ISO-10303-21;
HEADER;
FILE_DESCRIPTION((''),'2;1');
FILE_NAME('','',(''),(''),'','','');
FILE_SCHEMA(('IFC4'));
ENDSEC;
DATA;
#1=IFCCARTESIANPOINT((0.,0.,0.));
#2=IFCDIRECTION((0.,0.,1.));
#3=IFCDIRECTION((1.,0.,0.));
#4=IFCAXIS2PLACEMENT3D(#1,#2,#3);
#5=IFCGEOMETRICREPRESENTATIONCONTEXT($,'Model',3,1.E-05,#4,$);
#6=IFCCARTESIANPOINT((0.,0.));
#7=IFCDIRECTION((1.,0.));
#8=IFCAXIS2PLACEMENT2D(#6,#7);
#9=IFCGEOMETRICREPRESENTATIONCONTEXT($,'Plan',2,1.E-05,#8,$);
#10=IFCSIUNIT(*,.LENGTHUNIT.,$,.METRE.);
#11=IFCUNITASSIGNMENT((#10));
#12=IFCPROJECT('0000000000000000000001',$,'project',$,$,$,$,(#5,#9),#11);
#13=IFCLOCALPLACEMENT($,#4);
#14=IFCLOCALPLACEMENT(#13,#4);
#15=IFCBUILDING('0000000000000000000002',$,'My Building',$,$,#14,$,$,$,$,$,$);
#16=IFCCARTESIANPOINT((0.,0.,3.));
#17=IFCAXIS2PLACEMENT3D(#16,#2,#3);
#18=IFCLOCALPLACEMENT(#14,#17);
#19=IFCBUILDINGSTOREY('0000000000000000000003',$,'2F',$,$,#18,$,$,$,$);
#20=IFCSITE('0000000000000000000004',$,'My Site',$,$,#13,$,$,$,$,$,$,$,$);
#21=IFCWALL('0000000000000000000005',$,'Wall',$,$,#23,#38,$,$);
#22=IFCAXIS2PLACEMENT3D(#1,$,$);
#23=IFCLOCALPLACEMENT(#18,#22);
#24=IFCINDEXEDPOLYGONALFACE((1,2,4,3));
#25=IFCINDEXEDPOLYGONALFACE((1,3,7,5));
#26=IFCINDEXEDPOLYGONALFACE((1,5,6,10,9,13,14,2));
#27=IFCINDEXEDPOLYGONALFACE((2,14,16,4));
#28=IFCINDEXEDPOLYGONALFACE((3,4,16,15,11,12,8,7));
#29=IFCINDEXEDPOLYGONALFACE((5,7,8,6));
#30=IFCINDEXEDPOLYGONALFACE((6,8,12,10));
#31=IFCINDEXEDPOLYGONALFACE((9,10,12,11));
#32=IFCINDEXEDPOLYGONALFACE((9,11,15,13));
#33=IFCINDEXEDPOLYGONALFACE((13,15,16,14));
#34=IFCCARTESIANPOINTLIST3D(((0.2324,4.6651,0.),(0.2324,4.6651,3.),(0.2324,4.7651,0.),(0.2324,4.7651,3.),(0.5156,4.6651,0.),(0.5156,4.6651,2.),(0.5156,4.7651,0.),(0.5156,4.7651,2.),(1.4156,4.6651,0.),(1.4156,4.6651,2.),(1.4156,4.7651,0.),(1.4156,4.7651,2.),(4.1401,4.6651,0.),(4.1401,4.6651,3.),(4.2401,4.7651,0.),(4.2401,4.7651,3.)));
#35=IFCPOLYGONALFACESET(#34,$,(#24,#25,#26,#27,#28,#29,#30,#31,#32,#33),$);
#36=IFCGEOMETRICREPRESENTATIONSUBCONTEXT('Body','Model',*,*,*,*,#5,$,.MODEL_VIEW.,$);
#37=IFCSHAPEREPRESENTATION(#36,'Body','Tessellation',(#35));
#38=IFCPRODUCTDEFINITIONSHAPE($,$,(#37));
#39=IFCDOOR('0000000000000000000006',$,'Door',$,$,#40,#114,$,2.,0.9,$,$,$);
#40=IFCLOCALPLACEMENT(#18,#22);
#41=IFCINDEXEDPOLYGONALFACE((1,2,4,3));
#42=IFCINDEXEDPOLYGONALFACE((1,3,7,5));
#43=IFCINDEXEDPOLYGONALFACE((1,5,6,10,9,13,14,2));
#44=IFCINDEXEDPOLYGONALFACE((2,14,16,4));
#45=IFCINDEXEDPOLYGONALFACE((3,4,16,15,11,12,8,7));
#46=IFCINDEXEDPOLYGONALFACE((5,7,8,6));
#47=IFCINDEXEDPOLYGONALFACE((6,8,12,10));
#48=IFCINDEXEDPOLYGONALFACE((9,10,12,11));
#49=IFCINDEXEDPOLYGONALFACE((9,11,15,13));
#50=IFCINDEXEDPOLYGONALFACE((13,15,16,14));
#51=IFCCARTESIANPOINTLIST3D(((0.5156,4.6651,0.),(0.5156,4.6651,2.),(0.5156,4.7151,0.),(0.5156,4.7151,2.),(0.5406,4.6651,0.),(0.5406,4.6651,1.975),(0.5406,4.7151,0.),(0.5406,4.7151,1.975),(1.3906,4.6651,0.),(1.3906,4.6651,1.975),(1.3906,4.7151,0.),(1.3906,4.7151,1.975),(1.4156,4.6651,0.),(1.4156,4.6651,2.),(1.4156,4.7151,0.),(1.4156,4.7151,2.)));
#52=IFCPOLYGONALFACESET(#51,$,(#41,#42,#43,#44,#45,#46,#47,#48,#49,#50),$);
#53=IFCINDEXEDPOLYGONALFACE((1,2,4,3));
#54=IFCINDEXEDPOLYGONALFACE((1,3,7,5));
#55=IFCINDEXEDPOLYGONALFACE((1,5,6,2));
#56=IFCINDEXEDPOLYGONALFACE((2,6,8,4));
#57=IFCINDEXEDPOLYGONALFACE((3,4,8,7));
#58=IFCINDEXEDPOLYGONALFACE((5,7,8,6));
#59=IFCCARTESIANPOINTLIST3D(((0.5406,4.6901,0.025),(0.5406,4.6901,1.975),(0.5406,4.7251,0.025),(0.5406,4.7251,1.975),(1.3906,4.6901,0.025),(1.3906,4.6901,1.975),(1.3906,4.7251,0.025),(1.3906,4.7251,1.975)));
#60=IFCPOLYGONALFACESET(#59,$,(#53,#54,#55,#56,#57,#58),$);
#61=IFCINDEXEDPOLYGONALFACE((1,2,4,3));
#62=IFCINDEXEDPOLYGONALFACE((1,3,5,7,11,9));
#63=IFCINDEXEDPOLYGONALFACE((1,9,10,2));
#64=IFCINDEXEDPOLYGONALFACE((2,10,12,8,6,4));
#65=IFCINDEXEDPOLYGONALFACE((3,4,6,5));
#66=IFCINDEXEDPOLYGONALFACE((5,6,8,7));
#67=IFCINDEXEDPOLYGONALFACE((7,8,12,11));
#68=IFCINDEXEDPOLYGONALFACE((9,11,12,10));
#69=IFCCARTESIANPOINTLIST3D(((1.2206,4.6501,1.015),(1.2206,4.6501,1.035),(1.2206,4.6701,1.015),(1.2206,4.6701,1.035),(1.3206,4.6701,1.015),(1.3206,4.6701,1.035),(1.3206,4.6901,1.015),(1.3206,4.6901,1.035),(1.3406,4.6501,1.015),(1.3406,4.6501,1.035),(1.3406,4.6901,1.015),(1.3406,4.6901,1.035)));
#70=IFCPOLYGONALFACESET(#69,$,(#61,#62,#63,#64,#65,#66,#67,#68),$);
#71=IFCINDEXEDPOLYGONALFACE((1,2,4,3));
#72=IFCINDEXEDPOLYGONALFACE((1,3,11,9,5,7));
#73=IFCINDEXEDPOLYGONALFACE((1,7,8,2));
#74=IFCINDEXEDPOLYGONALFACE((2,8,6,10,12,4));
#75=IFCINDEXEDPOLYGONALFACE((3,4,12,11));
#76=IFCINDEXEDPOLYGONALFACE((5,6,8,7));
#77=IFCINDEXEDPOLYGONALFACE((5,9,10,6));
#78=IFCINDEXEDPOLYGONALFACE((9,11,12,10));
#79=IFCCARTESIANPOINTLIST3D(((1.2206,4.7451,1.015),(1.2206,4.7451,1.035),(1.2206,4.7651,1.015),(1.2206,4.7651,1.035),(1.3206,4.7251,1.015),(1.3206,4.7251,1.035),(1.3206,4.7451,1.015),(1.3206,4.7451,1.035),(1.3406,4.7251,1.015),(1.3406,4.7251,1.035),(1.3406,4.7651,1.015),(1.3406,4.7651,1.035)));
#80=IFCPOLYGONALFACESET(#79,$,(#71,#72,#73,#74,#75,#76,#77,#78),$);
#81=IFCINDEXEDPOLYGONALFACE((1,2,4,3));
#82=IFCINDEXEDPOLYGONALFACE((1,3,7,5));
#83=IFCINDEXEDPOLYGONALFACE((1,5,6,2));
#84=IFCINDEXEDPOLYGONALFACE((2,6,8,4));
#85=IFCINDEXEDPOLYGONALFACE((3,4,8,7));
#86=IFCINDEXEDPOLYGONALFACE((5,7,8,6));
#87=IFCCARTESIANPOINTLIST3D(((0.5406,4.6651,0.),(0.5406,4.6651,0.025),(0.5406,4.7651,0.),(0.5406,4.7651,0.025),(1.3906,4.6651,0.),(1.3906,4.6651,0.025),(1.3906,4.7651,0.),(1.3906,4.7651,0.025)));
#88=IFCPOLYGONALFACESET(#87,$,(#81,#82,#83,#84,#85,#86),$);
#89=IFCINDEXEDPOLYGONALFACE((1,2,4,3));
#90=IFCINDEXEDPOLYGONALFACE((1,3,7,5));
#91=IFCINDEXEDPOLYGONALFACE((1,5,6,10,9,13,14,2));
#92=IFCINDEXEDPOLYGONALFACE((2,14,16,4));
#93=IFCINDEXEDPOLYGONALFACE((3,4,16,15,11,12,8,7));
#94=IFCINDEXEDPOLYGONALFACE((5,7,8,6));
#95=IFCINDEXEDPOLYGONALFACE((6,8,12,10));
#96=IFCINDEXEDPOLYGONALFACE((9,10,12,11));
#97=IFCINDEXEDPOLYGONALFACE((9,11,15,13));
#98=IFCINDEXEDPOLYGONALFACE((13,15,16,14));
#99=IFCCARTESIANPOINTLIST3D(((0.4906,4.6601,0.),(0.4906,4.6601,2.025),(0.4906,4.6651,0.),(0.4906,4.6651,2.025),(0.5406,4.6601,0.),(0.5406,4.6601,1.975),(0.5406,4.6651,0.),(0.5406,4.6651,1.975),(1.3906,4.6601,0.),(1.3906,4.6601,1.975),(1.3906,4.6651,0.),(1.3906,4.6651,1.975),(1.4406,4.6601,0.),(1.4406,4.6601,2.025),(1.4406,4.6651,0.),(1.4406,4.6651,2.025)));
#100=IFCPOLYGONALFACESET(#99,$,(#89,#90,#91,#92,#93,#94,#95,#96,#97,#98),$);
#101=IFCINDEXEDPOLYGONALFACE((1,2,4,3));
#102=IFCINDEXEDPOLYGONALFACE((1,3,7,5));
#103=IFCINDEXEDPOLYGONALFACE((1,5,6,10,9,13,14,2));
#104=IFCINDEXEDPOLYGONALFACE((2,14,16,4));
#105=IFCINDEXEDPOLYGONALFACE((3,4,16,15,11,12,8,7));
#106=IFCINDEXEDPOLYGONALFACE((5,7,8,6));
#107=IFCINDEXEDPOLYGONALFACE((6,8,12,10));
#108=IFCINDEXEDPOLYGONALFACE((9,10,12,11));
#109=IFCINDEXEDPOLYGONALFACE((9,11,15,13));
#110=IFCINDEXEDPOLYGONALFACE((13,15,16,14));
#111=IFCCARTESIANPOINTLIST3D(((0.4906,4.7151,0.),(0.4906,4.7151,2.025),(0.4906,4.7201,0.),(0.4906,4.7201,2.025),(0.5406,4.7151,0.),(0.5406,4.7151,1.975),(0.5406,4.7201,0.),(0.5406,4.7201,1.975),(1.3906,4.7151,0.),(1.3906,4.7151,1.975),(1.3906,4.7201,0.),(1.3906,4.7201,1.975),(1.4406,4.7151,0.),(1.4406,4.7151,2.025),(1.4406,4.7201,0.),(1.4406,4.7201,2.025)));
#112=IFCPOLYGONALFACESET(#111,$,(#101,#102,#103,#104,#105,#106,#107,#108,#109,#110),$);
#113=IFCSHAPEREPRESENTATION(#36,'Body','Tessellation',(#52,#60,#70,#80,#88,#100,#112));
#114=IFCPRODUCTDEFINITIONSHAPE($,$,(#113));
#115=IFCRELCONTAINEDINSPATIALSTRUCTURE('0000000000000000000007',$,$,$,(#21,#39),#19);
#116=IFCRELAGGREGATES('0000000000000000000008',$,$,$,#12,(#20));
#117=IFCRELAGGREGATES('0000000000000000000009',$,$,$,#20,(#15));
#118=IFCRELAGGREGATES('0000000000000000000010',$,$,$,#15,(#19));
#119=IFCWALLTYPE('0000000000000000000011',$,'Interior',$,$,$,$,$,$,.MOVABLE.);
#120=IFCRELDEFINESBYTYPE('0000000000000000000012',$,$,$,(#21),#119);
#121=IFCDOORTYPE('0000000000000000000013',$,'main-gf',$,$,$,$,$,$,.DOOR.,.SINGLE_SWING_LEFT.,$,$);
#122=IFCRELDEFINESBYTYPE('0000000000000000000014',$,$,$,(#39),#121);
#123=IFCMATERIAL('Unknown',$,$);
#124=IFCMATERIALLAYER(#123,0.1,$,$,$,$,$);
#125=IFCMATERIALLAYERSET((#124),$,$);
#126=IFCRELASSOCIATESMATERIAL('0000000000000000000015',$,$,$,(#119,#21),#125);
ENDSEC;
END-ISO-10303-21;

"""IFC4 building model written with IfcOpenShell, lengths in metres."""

from ifc_helpers import new_model, entity, si_unit, frame, origin_with_axes, origin_2d_with_axis, place, context, subcontext, project, spatial, line, indexed_curve, outline, extrude, shape, source, transform, mapped, material, layer, layer_set, layer_usage, type_object, type_shapes, element, fill, save


model = new_model("IFC4")

# Units and contexts
model_context = context("Model", 3, precision=1e-05, world=origin_with_axes())
plan_context = context("Plan", 2, precision=1e-05, world=origin_2d_with_axis())
body_context_1 = subcontext(model_context, "Body", "Model", "MODEL_VIEW")
body_context_2 = subcontext(plan_context, "Body", "Plan", "PLAN_VIEW")
ifc_project = project(units=[si_unit("LENGTHUNIT", "METRE")], contexts=[model_context, plan_context])

# Site, building, storey
site_placement = place(None, origin_with_axes())
site = spatial("IfcSite", under=ifc_project, at=site_placement, Name="My Site")
building_placement = place(site_placement, origin_with_axes())
building = spatial("IfcBuilding", under=site, at=building_placement, Name="My Building")
storey_placement = place(building_placement, frame((0.0, 0.0, 3.0), z_axis=(0.0, 0.0, 1.0), x_axis=(1.0, 0.0, 0.0)))
storey = spatial("IfcBuildingStorey", under=building, at=storey_placement, Name="2F")

# Shared definitions
ifc_material = material(Name="Unknown")

# Shared definitions
ifc_layer_1 = layer(ifc_material, 0.1)
ifc_layer_set_1 = layer_set([ifc_layer_1])
wall_type = type_object("IfcWallType", Name="Interior", PredefinedType="MOVABLE", material=ifc_layer_set_1)

# Shared definitions
shared_shape_1 = source(origin_with_axes(), body_context_1, "Body", "SweptSolid", [
    extrude(outline(indexed_curve([(0.0, 0.0), (0.9, 0.0), (0.9, 2.0), (0.0, 2.0)], segments=[line(1, 2, 3, 4, 1)])), frame((0.0, -0.6, 0.0), z_axis=(0.0, -1.0, 0.0), x_axis=(1.0, 0.0, 0.0)), (0.0, 0.0, -1.0), 1.2),
])
door_type = type_object("IfcDoorType", Name="main-gf", OperationType="SINGLE_SWING_LEFT", PredefinedType="DOOR")
shared_shape_2 = source(origin_with_axes(), body_context_1, "Body", "SweptSolid", [
    extrude(outline(indexed_curve([(0.0, 0.0), (0.0, 2.0), (0.9, 2.0), (0.9, 0.0), (0.875, 0.0), (0.875, 1.975), (0.025, 1.975), (0.025, 0.0)], segments=[line(1, 2, 3, 4, 5, 6, 7, 8, 1)])), frame((0.0, 0.0, 0.0), z_axis=(0.0, -1.0, 0.0), x_axis=(1.0, 0.0, 0.0)), (0.0, 0.0, -1.0), 0.05),
    extrude(outline(indexed_curve([(0.0, 0.0), (0.85, 0.0), (0.85, 0.035), (0.0, 0.035)], segments=[line(1, 2, 3, 4, 1)])), frame((0.025, 0.025, 0.025), z_axis=(0.0, 0.0, 1.0), x_axis=(1.0, 0.0, 0.0)), (0.0, 0.0, 1.0), 1.95),
    extrude(outline(indexed_curve([(0.0, 0.0), (0.0, -0.04), (-0.12, -0.04), (-0.12, -0.02), (-0.02, -0.02), (-0.02, 0.0)], segments=[line(1, 2, 3, 4, 5, 6, 1)])), frame((0.825, 0.025, 1.015), z_axis=(0.0, 0.0, 1.0), x_axis=(1.0, 0.0, 0.0)), (0.0, 0.0, 1.0), 0.02),
    extrude(outline(indexed_curve([(0.0, 0.0), (0.0, 0.04), (-0.12, 0.04), (-0.12, 0.02), (-0.02, 0.02), (-0.02, 0.0)], segments=[line(1, 2, 3, 4, 5, 6, 1)])), frame((0.825, 0.06, 1.015), z_axis=(0.0, 0.0, 1.0), x_axis=(1.0, 0.0, 0.0)), (0.0, 0.0, 1.0), 0.02),
    extrude(outline(indexed_curve([(0.0, 0.0), (0.85, 0.0), (0.85, 0.1), (0.0, 0.1)], segments=[line(1, 2, 3, 4, 1)])), frame((0.025, 0.0, 0.0), z_axis=(0.0, 0.0, 1.0), x_axis=(1.0, 0.0, 0.0)), (0.0, 0.0, 1.0), 0.025),
    extrude(outline(indexed_curve([(0.0, 0.0), (0.0, 2.025), (0.95, 2.025), (0.95, 0.0), (0.9, 0.0), (0.9, 1.975), (0.05, 1.975), (0.05, 0.0)], segments=[line(1, 2, 3, 4, 5, 6, 7, 8, 1)])), frame((-0.025, -0.005, 0.0), z_axis=(0.0, -1.0, 0.0), x_axis=(1.0, 0.0, 0.0)), (0.0, 0.0, -1.0), 0.005),
    extrude(outline(indexed_curve([(0.0, 0.0), (0.0, 2.025), (0.95, 2.025), (0.95, 0.0), (0.9, 0.0), (0.9, 1.975), (0.05, 1.975), (0.05, 0.0)], segments=[line(1, 2, 3, 4, 5, 6, 7, 8, 1)])), frame((-0.025, 0.05, 0.0), z_axis=(0.0, -1.0, 0.0), x_axis=(1.0, 0.0, 0.0)), (0.0, 0.0, -1.0), 0.005),
])
shared_shape_3 = source(origin_with_axes(), body_context_2, "Body", "Curve2D", [
    entity("IfcIndexedPolyCurve", entity("IfcCartesianPointList2D", [[0.0, 0.0], [0.025, 0.0], [0.025, 0.05], [0.0, 0.05]]), [entity("IfcLineIndex", [1, 2, 3, 4, 1])]),
    entity("IfcIndexedPolyCurve", entity("IfcCartesianPointList2D", [[0.9, 0.0], [0.875, 0.0], [0.875, 0.05], [0.9, 0.05]]), [entity("IfcLineIndex", [1, 2, 3, 4, 1])]),
    entity("IfcIndexedPolyCurve", entity("IfcCartesianPointList2D", [[0.025, 0.05], [0.025, -0.8], [0.06, -0.8]])),
    entity("IfcTrimmedCurve", entity("IfcEllipse", entity("IfcAxis2Placement2D", entity("IfcCartesianPoint", [0.06, 0.05]), entity("IfcDirection", [1.0, 0.0])), 0.815, 0.85), [entity("IfcCartesianPoint", [0.06, -0.8])], [entity("IfcCartesianPoint", [0.06, 0.9])], True, "CARTESIAN"),
    entity("IfcIndexedPolyCurve", entity("IfcCartesianPointList2D", [[0.025, 0.05], [0.06, 0.05], [0.06, 0.9], [0.025, 0.9]]), [entity("IfcLineIndex", [1, 2, 3, 4, 1])]),
])
type_shapes(door_type, [shared_shape_2, shared_shape_3])

# Wall, opening, door
ifc_layer_usage_1 = layer_usage(ifc_layer_set_1, "AXIS2", "POSITIVE", 0.0)
wall_1_placement = place(storey_placement, frame((4.1401, 4.7651, 0.0), z_axis=(0.0, 0.0, 1.0), x_axis=(-1.0, 0.0, 0.0)))
wall_1 = element("IfcWall", 1, at=wall_1_placement, inside=storey, type_object=wall_type, material=ifc_layer_usage_1, Name="Wall", context=body_context_1, shape_type="SweptSolid", body=[
    extrude(outline(indexed_curve([(-0.1, 0.0), (0.0, 0.1), (3.9077, 0.1), (3.9077, 0.0)], segments=[line(1, 2, 3, 4, 1)])), origin_with_axes(), (0.0, 0.0, 1.0), 3.0),
])
opening_1_placement = place(wall_1_placement, frame((3.6245, 0.1, 0.0), z_axis=(0.0, 0.0, 1.0), x_axis=(-1.0, 0.0, 0.0)))
opening_1 = element("IfcOpeningElement", 2, at=opening_1_placement, cuts=wall_1, PredefinedType="OPENING", context=body_context_1, shape_type="MappedRepresentation", body=[
    mapped(shared_shape_1, transform((0.0, 0.0, 0.0), x_axis=(1.0, 0.0, 0.0), y_axis=(0.0, 1.0, 0.0), z_axis=(0.0, 0.0, 1.0), scale=1.0)),
])
door_1_placement = place(opening_1_placement, frame((0.0, 0.0, 0.0), z_axis=(0.0, 0.0, 1.0), x_axis=(1.0, 0.0, 0.0)))
door_1 = element("IfcDoor", 3, at=door_1_placement, inside=storey, type_object=door_type, Name="Door", OverallHeight=2.0, OverallWidth=0.9, shapes=[
    shape(body_context_1, "Body", "MappedRepresentation", [mapped(shared_shape_2, transform((0.0, 0.0, 0.0), x_axis=(1.0, 0.0, 0.0), y_axis=(0.0, 1.0, 0.0), z_axis=(0.0, 0.0, 1.0), scale=1.0))]),
    shape(body_context_2, "Body", "MappedRepresentation", [mapped(shared_shape_3, transform((0.0, 0.0, 0.0), x_axis=(1.0, 0.0, 0.0), y_axis=(0.0, 1.0, 0.0), z_axis=(0.0, 0.0, 1.0), scale=1.0))]),
])
fill(opening_1, door_1)

save(model, "model.ifc")
